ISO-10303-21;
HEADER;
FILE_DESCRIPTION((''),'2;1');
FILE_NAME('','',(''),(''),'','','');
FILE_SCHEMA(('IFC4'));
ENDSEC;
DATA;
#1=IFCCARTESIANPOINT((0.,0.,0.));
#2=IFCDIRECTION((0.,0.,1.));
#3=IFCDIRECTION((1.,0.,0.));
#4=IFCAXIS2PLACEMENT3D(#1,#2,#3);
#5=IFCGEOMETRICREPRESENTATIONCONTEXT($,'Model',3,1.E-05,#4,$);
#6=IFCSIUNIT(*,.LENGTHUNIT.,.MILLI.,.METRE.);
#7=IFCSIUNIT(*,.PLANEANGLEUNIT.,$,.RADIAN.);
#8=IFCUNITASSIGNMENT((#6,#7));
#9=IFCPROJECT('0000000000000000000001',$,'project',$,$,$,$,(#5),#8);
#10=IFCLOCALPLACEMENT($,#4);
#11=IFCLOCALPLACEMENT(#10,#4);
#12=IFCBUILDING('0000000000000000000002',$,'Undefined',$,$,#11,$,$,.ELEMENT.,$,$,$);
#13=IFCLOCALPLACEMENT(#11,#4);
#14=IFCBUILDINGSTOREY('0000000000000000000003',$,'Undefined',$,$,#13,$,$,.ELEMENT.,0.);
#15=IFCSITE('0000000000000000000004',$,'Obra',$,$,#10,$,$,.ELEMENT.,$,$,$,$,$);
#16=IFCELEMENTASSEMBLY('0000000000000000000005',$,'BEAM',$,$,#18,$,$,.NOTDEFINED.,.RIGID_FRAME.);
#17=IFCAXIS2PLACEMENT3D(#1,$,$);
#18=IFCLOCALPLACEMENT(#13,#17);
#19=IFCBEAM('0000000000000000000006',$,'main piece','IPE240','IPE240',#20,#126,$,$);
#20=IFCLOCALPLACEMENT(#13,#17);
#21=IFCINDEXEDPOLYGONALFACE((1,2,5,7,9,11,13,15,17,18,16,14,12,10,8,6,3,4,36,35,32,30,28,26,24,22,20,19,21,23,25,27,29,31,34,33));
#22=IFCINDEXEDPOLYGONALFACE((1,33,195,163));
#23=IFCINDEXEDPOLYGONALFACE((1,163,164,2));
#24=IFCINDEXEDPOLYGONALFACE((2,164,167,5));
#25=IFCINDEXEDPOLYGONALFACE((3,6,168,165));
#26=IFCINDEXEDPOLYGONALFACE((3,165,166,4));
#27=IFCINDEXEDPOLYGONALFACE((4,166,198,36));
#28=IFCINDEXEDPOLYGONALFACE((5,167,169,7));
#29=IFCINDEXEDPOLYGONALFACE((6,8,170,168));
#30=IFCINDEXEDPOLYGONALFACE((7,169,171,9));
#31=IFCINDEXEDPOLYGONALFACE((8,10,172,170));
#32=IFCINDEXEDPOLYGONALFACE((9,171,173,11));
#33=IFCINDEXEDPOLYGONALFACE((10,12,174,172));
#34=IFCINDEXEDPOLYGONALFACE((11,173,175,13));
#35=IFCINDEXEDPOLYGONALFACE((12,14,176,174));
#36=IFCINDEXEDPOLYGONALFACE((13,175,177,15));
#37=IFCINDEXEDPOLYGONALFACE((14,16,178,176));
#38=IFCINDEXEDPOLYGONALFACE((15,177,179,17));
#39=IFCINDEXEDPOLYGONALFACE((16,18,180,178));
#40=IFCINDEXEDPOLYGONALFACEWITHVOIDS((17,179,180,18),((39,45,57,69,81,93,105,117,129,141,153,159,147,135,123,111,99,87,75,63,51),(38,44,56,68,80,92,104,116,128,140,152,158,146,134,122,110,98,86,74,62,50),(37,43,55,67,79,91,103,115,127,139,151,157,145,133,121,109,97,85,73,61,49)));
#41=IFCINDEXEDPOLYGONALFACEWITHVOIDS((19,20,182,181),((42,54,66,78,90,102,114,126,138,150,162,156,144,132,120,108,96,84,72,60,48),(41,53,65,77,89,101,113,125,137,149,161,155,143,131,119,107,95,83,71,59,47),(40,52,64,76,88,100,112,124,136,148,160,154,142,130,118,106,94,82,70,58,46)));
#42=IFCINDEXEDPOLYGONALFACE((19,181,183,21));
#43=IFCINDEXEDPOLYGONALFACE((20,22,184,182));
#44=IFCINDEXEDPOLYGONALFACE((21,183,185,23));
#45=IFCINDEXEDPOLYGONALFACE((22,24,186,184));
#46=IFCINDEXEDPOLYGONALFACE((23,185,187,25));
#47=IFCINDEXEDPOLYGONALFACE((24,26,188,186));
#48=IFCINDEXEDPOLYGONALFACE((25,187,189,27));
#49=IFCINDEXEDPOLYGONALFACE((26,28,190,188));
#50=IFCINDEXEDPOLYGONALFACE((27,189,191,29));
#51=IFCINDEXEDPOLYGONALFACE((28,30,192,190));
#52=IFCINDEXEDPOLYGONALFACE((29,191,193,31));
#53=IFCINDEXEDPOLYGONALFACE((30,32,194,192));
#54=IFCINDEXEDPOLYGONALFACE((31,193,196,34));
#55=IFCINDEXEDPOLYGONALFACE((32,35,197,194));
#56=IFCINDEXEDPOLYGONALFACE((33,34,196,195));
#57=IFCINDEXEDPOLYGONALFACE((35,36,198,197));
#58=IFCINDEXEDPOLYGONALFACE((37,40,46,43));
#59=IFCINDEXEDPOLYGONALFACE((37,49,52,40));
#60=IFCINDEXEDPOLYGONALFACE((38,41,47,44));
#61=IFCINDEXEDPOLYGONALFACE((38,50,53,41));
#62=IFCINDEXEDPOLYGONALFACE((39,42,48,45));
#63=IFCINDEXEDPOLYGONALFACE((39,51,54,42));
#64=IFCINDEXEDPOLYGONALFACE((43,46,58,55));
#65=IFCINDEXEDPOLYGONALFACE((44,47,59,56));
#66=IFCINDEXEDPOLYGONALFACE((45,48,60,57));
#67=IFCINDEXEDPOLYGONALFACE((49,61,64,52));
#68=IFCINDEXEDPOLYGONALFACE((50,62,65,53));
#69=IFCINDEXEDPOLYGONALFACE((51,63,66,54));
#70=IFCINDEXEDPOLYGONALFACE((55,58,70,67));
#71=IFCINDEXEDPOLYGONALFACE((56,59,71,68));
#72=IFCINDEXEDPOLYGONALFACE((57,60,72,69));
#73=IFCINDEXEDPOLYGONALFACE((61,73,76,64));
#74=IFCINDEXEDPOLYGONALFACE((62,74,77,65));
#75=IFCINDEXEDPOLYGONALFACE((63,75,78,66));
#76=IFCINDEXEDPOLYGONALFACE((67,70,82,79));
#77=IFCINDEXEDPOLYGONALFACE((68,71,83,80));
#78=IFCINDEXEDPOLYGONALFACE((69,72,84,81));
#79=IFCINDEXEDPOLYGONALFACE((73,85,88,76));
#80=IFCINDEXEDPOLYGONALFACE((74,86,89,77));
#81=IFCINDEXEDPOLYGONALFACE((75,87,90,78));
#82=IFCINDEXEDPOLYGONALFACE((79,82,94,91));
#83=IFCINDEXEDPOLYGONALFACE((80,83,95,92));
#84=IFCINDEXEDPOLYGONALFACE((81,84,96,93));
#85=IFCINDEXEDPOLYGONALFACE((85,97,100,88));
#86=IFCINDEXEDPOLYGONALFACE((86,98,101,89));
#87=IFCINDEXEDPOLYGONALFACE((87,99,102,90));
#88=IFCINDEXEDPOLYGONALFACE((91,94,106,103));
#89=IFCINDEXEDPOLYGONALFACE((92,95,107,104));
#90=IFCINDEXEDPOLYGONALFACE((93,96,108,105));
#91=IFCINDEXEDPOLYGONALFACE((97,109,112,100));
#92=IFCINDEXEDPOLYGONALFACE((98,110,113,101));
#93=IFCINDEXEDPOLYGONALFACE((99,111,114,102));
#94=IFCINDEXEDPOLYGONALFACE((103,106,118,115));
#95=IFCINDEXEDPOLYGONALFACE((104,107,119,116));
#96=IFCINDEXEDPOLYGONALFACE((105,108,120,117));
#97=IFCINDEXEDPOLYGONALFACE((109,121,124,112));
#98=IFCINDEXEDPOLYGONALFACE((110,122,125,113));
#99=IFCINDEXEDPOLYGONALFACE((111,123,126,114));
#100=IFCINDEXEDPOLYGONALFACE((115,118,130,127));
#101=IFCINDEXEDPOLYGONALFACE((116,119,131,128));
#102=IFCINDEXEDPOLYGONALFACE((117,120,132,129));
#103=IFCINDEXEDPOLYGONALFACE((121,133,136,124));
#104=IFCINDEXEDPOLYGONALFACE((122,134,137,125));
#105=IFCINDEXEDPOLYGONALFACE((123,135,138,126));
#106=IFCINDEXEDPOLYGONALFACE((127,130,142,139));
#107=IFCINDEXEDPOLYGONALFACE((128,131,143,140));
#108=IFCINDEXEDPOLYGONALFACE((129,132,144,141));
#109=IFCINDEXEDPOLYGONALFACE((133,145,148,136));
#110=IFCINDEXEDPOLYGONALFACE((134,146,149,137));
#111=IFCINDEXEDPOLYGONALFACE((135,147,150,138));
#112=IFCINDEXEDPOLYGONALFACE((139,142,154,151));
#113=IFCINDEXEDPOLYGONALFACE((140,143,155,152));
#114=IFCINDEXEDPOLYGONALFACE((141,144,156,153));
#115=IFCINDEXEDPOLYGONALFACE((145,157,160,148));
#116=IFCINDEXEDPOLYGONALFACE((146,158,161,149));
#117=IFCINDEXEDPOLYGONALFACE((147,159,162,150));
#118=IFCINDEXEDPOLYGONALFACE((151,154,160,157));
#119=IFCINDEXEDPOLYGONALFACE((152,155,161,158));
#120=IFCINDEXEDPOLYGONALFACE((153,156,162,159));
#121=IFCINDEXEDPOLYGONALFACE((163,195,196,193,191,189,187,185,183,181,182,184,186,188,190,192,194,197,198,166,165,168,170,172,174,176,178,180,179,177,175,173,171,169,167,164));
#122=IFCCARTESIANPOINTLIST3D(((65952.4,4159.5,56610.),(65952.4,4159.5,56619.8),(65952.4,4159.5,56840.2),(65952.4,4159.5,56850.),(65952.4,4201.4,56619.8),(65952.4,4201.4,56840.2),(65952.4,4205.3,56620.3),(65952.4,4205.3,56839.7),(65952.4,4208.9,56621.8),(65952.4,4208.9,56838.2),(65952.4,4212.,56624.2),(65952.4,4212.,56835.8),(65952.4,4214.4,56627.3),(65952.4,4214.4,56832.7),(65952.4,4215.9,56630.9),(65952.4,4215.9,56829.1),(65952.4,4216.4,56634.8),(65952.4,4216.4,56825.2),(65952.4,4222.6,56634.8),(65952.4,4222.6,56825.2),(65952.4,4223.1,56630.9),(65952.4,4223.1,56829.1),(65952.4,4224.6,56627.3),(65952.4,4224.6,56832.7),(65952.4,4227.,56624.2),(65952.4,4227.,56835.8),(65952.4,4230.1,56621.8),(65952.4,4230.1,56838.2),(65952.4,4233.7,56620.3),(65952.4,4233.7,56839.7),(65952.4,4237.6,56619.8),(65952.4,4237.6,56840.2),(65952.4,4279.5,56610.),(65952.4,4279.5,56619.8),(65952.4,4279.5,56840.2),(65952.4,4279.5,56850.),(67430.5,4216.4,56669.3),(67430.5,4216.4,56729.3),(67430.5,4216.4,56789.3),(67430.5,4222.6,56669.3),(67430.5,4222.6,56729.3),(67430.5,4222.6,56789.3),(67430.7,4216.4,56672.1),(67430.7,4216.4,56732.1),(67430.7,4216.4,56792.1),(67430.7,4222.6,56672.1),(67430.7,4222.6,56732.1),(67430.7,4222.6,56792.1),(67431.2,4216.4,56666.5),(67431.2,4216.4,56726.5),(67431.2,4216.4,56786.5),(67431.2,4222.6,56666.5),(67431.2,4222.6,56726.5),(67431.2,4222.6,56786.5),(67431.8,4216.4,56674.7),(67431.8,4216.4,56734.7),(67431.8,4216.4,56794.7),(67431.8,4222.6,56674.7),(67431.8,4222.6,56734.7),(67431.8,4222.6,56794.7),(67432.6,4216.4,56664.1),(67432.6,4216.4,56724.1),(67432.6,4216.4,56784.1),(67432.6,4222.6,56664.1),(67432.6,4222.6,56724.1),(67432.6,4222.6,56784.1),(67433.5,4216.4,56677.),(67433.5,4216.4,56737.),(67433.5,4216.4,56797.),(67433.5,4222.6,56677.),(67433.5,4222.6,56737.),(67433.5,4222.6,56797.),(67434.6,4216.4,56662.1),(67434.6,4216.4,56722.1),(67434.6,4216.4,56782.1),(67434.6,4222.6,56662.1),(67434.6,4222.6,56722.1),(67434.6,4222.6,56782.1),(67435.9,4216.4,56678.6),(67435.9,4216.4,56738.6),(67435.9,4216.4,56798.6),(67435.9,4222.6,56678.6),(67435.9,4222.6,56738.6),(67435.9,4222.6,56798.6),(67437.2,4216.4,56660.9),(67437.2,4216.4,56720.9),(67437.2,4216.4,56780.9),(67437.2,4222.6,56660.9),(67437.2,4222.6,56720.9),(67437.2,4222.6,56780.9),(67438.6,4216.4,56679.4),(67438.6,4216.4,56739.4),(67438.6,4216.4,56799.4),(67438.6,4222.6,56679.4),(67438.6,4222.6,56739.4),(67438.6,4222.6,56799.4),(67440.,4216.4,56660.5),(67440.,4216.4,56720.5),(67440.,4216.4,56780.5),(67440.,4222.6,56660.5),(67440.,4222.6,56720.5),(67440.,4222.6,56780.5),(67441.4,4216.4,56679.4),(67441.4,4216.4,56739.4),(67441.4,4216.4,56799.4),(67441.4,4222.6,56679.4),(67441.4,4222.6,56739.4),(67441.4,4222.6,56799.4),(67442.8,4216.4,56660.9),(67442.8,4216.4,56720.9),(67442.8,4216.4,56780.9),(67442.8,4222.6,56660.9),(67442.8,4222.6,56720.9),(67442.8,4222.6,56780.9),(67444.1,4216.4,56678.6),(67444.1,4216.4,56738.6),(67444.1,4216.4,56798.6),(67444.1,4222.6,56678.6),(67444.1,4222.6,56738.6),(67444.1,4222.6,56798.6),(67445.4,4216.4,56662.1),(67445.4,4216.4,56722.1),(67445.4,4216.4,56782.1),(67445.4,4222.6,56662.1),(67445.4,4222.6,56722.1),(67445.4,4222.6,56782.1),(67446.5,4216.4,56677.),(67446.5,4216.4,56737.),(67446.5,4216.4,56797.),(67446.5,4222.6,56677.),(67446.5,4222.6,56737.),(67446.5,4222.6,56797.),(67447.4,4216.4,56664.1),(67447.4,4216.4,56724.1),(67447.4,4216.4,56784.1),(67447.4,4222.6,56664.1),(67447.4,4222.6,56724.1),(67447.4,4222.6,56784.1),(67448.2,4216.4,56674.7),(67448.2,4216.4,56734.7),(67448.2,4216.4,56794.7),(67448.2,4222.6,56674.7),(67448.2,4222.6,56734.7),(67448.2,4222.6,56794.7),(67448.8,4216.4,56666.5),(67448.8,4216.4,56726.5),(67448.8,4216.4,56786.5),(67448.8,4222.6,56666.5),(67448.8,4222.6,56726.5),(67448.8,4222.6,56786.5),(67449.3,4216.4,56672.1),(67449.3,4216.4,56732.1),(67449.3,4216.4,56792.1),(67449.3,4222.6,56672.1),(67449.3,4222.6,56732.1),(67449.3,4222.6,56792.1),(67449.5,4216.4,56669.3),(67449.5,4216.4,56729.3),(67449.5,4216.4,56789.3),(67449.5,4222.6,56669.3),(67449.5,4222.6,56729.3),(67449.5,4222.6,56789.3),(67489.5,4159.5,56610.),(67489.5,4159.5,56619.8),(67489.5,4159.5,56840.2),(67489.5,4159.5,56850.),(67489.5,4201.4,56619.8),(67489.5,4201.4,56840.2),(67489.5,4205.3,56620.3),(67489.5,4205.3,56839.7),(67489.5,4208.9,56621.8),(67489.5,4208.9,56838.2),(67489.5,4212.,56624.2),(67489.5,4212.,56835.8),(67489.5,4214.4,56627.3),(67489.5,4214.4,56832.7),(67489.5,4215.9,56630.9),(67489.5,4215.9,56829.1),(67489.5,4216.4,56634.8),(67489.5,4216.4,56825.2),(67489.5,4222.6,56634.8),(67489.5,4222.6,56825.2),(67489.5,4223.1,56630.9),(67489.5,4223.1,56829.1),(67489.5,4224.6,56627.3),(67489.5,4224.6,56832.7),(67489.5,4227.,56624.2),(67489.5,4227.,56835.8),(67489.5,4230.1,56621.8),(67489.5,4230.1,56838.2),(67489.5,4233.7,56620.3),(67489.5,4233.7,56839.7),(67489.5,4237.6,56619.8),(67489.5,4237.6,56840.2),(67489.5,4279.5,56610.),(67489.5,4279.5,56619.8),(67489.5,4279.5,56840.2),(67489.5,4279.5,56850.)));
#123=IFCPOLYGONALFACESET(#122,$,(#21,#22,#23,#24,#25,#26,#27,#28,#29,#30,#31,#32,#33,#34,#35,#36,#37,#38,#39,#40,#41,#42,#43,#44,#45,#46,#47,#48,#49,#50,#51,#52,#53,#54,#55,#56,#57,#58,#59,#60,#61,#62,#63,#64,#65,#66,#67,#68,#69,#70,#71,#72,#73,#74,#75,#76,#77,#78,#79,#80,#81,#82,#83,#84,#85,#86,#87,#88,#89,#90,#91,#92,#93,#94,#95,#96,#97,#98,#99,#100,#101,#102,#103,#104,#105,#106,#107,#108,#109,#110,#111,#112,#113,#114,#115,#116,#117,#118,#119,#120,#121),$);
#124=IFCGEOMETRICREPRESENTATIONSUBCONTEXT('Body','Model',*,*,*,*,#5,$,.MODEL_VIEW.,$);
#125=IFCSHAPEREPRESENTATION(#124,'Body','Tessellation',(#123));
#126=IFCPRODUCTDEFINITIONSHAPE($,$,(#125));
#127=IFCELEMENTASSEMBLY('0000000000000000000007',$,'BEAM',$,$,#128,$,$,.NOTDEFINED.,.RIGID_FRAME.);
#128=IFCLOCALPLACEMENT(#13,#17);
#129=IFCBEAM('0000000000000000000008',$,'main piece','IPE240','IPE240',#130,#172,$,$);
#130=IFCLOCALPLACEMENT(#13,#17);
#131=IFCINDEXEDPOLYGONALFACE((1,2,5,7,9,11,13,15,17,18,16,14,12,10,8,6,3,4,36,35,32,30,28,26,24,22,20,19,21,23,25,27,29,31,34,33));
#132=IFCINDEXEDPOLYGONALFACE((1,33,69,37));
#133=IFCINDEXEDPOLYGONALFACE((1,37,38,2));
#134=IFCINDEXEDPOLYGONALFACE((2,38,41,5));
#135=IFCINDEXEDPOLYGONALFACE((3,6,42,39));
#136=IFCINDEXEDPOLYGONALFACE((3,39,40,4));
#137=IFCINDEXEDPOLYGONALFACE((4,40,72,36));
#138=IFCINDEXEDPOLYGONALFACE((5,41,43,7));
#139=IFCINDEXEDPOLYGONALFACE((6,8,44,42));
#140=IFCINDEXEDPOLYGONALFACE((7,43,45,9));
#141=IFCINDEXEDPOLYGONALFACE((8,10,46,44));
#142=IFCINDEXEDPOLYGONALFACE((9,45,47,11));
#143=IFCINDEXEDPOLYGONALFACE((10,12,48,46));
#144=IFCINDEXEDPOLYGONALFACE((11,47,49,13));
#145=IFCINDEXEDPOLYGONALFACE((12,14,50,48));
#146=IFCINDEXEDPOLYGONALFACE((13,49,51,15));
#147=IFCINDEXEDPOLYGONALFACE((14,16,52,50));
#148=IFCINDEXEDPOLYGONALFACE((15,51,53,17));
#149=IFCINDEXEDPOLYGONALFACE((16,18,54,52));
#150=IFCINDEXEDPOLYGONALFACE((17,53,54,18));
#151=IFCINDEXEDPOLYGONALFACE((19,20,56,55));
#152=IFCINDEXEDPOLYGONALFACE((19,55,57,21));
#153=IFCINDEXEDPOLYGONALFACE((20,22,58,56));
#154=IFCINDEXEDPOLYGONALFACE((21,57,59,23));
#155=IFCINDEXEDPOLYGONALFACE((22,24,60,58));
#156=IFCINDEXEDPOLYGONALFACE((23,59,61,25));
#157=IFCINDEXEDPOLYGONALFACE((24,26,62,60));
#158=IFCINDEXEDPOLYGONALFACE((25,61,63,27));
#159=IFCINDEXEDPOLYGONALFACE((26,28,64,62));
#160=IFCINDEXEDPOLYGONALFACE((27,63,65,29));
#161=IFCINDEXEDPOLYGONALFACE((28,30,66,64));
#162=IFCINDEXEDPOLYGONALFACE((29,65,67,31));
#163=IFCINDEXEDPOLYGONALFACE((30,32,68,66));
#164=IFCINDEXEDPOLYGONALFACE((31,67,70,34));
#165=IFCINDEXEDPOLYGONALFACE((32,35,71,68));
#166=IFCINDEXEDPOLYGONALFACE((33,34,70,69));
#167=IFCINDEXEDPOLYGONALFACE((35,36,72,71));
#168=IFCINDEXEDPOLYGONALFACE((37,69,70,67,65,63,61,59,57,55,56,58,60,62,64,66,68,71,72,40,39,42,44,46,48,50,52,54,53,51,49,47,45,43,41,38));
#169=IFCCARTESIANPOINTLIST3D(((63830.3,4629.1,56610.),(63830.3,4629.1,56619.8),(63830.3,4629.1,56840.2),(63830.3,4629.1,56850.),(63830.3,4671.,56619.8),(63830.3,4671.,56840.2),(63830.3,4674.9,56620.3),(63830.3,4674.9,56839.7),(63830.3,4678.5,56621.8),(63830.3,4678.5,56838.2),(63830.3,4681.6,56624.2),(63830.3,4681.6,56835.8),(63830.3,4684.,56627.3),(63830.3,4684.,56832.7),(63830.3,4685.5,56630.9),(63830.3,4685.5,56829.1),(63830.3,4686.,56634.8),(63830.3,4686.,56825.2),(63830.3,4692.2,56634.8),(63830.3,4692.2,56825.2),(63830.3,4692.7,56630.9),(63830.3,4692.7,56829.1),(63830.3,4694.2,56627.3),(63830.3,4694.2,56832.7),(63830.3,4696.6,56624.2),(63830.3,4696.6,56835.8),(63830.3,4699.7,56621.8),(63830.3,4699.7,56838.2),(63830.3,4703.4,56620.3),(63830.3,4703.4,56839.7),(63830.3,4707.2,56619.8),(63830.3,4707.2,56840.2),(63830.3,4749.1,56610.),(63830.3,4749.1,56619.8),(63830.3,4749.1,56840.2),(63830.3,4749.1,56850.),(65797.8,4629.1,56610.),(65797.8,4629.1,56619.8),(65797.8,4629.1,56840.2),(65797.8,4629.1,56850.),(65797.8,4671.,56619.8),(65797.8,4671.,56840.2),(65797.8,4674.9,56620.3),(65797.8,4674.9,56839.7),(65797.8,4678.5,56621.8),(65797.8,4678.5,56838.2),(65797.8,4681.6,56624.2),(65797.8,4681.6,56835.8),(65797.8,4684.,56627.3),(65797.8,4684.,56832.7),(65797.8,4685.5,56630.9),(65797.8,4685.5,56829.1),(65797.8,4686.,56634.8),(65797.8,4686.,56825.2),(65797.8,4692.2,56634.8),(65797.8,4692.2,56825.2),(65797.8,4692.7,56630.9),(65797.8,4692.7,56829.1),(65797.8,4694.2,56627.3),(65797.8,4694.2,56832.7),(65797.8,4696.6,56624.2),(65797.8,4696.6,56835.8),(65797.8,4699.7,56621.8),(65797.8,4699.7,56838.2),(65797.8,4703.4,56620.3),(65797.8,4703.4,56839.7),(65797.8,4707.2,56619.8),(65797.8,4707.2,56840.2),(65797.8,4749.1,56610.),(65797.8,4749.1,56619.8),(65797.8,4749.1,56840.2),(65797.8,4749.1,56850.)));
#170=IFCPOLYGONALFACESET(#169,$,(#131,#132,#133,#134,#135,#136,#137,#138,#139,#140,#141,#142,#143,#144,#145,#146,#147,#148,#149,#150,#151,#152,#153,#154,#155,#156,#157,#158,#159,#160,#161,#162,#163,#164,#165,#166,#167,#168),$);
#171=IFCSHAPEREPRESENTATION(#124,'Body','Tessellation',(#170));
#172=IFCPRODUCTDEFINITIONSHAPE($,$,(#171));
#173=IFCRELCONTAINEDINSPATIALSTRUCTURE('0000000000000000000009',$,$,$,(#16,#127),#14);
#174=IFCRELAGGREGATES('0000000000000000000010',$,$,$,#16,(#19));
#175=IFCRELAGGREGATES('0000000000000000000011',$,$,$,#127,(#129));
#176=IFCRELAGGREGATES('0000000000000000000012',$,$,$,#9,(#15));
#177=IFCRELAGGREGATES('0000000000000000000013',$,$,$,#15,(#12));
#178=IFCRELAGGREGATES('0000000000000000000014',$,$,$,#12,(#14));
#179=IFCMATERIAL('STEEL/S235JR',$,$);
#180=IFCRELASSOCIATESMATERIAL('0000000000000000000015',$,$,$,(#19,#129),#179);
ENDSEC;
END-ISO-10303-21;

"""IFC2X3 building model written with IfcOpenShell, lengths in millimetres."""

from ifc_helpers import new_model, si_unit, frame, origin_with_axes, origin_2d_with_axis, place, context, subcontext, project, spatial, circle, i_section, extrude, clip, halfspace, source, transform, mapped, material, element, aggregate, save


model = new_model("IFC2X3")

# Units and contexts
model_context = context("Model", 3, precision=1e-05, world=origin_with_axes())
body_context = subcontext(model_context, "Body", "Model", "MODEL_VIEW")
ifc_project = project(units=[si_unit("LENGTHUNIT", "METRE", prefix="MILLI"), si_unit("PLANEANGLEUNIT", "RADIAN")], contexts=[model_context])

# Site, building, storey
site_placement = place(None, origin_with_axes())
site = spatial("IfcSite", under=ifc_project, at=site_placement, Name="Obra", CompositionType="ELEMENT")
building_placement = place(site_placement, origin_with_axes())
building = spatial("IfcBuilding", under=site, at=building_placement, Name="Undefined", CompositionType="ELEMENT")
storey_placement = place(building_placement, origin_with_axes())
storey = spatial("IfcBuildingStorey", under=building, at=storey_placement, Name="Undefined", CompositionType="ELEMENT", Elevation=0.0)

# Shared definitions
ifc_material_1 = material(Name="STEEL/S235JR")

# Element assembly, beam, opening
shared_shape_1 = source(origin_with_axes(), body_context, "Body", "SweptSolid", [
    extrude(circle(Radius=9.5, at=origin_2d_with_axis()), frame((0.0, -3.2, 0.0), z_axis=(0.0, 1.0, 0.0), x_axis=(1.0, 0.0, 0.0)), (0.0, 0.0, 1.0), 6.4),
])
assembly_1_placement = place(storey_placement, origin_with_axes())
assembly_1 = element("IfcElementAssembly", 1, at=assembly_1_placement, inside=storey, Name="BEAM", AssemblyPlace="NOTDEFINED", PredefinedType="RIGID_FRAME")
beam_1_placement = place(assembly_1_placement, frame((65952.4, 4219.5, 56730.0), z_axis=(0.0, 0.0, 1.0), x_axis=(1.0, 0.0, 0.0)))
beam_1 = element("IfcBeam", 2, at=beam_1_placement, material=ifc_material_1, Name="main piece", Description="IPE240", ObjectType="IPE240", context=body_context, shape_type="Clipping", body=[
    clip(extrude(i_section(OverallWidth=120.0, OverallDepth=240.0, WebThickness=6.2, FlangeThickness=9.8, FilletRadius=15.0, at=origin_2d_with_axis()), frame((1741.1, 0.0, 0.0), z_axis=(-1.0, 0.0, 0.0), x_axis=(0.0, -1.0, 0.0)), (0.0, 0.0, 1.0), 1741.1), halfspace(frame((1537.1, -60.0, -120.0), z_axis=(1.0, 0.000019, 0.0), x_axis=(0.0, 0.0, 1.0)), False)),
])
opening_1_placement = place(assembly_1_placement, frame((67490.0, 4219.5, 56850.0), z_axis=(-1.0, 0.0, 0.0), x_axis=(0.0, 0.0, -1.0)))
element("IfcOpeningElement", 3, at=opening_1_placement, cuts=beam_1, ObjectType="Opening", context=body_context, shape_type="MappedRepresentation", body=[
    mapped(shared_shape_1, transform((60.0, 0.0, 50.0))),
    mapped(shared_shape_1, transform((120.0, 0.0, 50.0))),
    mapped(shared_shape_1, transform((180.0, 0.0, 50.0))),
])
aggregate(assembly_1, [beam_1])

# Element assembly, beam
assembly_2_placement = place(storey_placement, origin_with_axes())
assembly_2 = element("IfcElementAssembly", 4, at=assembly_2_placement, inside=storey, Name="BEAM", AssemblyPlace="NOTDEFINED", PredefinedType="RIGID_FRAME")
beam_2_placement = place(assembly_2_placement, frame((65797.8, 4689.1, 56730.0), z_axis=(0.0, 0.0, 1.0), x_axis=(-1.0, 0.0, 0.0)))
beam_2 = element("IfcBeam", 5, at=beam_2_placement, material=ifc_material_1, Name="main piece", Description="IPE240", ObjectType="IPE240", context=body_context, shape_type="SweptSolid", body=[
    extrude(i_section(OverallWidth=120.0, OverallDepth=240.0, WebThickness=6.2, FlangeThickness=9.8, FilletRadius=15.0, at=origin_2d_with_axis()), frame((1967.5, 0.0, 0.0), z_axis=(-1.0, 0.0, 0.0), x_axis=(0.0, -1.0, 0.0)), (0.0, 0.0, 1.0), 1967.5),
])
aggregate(assembly_2, [beam_2])

save(model, "model.ifc")
